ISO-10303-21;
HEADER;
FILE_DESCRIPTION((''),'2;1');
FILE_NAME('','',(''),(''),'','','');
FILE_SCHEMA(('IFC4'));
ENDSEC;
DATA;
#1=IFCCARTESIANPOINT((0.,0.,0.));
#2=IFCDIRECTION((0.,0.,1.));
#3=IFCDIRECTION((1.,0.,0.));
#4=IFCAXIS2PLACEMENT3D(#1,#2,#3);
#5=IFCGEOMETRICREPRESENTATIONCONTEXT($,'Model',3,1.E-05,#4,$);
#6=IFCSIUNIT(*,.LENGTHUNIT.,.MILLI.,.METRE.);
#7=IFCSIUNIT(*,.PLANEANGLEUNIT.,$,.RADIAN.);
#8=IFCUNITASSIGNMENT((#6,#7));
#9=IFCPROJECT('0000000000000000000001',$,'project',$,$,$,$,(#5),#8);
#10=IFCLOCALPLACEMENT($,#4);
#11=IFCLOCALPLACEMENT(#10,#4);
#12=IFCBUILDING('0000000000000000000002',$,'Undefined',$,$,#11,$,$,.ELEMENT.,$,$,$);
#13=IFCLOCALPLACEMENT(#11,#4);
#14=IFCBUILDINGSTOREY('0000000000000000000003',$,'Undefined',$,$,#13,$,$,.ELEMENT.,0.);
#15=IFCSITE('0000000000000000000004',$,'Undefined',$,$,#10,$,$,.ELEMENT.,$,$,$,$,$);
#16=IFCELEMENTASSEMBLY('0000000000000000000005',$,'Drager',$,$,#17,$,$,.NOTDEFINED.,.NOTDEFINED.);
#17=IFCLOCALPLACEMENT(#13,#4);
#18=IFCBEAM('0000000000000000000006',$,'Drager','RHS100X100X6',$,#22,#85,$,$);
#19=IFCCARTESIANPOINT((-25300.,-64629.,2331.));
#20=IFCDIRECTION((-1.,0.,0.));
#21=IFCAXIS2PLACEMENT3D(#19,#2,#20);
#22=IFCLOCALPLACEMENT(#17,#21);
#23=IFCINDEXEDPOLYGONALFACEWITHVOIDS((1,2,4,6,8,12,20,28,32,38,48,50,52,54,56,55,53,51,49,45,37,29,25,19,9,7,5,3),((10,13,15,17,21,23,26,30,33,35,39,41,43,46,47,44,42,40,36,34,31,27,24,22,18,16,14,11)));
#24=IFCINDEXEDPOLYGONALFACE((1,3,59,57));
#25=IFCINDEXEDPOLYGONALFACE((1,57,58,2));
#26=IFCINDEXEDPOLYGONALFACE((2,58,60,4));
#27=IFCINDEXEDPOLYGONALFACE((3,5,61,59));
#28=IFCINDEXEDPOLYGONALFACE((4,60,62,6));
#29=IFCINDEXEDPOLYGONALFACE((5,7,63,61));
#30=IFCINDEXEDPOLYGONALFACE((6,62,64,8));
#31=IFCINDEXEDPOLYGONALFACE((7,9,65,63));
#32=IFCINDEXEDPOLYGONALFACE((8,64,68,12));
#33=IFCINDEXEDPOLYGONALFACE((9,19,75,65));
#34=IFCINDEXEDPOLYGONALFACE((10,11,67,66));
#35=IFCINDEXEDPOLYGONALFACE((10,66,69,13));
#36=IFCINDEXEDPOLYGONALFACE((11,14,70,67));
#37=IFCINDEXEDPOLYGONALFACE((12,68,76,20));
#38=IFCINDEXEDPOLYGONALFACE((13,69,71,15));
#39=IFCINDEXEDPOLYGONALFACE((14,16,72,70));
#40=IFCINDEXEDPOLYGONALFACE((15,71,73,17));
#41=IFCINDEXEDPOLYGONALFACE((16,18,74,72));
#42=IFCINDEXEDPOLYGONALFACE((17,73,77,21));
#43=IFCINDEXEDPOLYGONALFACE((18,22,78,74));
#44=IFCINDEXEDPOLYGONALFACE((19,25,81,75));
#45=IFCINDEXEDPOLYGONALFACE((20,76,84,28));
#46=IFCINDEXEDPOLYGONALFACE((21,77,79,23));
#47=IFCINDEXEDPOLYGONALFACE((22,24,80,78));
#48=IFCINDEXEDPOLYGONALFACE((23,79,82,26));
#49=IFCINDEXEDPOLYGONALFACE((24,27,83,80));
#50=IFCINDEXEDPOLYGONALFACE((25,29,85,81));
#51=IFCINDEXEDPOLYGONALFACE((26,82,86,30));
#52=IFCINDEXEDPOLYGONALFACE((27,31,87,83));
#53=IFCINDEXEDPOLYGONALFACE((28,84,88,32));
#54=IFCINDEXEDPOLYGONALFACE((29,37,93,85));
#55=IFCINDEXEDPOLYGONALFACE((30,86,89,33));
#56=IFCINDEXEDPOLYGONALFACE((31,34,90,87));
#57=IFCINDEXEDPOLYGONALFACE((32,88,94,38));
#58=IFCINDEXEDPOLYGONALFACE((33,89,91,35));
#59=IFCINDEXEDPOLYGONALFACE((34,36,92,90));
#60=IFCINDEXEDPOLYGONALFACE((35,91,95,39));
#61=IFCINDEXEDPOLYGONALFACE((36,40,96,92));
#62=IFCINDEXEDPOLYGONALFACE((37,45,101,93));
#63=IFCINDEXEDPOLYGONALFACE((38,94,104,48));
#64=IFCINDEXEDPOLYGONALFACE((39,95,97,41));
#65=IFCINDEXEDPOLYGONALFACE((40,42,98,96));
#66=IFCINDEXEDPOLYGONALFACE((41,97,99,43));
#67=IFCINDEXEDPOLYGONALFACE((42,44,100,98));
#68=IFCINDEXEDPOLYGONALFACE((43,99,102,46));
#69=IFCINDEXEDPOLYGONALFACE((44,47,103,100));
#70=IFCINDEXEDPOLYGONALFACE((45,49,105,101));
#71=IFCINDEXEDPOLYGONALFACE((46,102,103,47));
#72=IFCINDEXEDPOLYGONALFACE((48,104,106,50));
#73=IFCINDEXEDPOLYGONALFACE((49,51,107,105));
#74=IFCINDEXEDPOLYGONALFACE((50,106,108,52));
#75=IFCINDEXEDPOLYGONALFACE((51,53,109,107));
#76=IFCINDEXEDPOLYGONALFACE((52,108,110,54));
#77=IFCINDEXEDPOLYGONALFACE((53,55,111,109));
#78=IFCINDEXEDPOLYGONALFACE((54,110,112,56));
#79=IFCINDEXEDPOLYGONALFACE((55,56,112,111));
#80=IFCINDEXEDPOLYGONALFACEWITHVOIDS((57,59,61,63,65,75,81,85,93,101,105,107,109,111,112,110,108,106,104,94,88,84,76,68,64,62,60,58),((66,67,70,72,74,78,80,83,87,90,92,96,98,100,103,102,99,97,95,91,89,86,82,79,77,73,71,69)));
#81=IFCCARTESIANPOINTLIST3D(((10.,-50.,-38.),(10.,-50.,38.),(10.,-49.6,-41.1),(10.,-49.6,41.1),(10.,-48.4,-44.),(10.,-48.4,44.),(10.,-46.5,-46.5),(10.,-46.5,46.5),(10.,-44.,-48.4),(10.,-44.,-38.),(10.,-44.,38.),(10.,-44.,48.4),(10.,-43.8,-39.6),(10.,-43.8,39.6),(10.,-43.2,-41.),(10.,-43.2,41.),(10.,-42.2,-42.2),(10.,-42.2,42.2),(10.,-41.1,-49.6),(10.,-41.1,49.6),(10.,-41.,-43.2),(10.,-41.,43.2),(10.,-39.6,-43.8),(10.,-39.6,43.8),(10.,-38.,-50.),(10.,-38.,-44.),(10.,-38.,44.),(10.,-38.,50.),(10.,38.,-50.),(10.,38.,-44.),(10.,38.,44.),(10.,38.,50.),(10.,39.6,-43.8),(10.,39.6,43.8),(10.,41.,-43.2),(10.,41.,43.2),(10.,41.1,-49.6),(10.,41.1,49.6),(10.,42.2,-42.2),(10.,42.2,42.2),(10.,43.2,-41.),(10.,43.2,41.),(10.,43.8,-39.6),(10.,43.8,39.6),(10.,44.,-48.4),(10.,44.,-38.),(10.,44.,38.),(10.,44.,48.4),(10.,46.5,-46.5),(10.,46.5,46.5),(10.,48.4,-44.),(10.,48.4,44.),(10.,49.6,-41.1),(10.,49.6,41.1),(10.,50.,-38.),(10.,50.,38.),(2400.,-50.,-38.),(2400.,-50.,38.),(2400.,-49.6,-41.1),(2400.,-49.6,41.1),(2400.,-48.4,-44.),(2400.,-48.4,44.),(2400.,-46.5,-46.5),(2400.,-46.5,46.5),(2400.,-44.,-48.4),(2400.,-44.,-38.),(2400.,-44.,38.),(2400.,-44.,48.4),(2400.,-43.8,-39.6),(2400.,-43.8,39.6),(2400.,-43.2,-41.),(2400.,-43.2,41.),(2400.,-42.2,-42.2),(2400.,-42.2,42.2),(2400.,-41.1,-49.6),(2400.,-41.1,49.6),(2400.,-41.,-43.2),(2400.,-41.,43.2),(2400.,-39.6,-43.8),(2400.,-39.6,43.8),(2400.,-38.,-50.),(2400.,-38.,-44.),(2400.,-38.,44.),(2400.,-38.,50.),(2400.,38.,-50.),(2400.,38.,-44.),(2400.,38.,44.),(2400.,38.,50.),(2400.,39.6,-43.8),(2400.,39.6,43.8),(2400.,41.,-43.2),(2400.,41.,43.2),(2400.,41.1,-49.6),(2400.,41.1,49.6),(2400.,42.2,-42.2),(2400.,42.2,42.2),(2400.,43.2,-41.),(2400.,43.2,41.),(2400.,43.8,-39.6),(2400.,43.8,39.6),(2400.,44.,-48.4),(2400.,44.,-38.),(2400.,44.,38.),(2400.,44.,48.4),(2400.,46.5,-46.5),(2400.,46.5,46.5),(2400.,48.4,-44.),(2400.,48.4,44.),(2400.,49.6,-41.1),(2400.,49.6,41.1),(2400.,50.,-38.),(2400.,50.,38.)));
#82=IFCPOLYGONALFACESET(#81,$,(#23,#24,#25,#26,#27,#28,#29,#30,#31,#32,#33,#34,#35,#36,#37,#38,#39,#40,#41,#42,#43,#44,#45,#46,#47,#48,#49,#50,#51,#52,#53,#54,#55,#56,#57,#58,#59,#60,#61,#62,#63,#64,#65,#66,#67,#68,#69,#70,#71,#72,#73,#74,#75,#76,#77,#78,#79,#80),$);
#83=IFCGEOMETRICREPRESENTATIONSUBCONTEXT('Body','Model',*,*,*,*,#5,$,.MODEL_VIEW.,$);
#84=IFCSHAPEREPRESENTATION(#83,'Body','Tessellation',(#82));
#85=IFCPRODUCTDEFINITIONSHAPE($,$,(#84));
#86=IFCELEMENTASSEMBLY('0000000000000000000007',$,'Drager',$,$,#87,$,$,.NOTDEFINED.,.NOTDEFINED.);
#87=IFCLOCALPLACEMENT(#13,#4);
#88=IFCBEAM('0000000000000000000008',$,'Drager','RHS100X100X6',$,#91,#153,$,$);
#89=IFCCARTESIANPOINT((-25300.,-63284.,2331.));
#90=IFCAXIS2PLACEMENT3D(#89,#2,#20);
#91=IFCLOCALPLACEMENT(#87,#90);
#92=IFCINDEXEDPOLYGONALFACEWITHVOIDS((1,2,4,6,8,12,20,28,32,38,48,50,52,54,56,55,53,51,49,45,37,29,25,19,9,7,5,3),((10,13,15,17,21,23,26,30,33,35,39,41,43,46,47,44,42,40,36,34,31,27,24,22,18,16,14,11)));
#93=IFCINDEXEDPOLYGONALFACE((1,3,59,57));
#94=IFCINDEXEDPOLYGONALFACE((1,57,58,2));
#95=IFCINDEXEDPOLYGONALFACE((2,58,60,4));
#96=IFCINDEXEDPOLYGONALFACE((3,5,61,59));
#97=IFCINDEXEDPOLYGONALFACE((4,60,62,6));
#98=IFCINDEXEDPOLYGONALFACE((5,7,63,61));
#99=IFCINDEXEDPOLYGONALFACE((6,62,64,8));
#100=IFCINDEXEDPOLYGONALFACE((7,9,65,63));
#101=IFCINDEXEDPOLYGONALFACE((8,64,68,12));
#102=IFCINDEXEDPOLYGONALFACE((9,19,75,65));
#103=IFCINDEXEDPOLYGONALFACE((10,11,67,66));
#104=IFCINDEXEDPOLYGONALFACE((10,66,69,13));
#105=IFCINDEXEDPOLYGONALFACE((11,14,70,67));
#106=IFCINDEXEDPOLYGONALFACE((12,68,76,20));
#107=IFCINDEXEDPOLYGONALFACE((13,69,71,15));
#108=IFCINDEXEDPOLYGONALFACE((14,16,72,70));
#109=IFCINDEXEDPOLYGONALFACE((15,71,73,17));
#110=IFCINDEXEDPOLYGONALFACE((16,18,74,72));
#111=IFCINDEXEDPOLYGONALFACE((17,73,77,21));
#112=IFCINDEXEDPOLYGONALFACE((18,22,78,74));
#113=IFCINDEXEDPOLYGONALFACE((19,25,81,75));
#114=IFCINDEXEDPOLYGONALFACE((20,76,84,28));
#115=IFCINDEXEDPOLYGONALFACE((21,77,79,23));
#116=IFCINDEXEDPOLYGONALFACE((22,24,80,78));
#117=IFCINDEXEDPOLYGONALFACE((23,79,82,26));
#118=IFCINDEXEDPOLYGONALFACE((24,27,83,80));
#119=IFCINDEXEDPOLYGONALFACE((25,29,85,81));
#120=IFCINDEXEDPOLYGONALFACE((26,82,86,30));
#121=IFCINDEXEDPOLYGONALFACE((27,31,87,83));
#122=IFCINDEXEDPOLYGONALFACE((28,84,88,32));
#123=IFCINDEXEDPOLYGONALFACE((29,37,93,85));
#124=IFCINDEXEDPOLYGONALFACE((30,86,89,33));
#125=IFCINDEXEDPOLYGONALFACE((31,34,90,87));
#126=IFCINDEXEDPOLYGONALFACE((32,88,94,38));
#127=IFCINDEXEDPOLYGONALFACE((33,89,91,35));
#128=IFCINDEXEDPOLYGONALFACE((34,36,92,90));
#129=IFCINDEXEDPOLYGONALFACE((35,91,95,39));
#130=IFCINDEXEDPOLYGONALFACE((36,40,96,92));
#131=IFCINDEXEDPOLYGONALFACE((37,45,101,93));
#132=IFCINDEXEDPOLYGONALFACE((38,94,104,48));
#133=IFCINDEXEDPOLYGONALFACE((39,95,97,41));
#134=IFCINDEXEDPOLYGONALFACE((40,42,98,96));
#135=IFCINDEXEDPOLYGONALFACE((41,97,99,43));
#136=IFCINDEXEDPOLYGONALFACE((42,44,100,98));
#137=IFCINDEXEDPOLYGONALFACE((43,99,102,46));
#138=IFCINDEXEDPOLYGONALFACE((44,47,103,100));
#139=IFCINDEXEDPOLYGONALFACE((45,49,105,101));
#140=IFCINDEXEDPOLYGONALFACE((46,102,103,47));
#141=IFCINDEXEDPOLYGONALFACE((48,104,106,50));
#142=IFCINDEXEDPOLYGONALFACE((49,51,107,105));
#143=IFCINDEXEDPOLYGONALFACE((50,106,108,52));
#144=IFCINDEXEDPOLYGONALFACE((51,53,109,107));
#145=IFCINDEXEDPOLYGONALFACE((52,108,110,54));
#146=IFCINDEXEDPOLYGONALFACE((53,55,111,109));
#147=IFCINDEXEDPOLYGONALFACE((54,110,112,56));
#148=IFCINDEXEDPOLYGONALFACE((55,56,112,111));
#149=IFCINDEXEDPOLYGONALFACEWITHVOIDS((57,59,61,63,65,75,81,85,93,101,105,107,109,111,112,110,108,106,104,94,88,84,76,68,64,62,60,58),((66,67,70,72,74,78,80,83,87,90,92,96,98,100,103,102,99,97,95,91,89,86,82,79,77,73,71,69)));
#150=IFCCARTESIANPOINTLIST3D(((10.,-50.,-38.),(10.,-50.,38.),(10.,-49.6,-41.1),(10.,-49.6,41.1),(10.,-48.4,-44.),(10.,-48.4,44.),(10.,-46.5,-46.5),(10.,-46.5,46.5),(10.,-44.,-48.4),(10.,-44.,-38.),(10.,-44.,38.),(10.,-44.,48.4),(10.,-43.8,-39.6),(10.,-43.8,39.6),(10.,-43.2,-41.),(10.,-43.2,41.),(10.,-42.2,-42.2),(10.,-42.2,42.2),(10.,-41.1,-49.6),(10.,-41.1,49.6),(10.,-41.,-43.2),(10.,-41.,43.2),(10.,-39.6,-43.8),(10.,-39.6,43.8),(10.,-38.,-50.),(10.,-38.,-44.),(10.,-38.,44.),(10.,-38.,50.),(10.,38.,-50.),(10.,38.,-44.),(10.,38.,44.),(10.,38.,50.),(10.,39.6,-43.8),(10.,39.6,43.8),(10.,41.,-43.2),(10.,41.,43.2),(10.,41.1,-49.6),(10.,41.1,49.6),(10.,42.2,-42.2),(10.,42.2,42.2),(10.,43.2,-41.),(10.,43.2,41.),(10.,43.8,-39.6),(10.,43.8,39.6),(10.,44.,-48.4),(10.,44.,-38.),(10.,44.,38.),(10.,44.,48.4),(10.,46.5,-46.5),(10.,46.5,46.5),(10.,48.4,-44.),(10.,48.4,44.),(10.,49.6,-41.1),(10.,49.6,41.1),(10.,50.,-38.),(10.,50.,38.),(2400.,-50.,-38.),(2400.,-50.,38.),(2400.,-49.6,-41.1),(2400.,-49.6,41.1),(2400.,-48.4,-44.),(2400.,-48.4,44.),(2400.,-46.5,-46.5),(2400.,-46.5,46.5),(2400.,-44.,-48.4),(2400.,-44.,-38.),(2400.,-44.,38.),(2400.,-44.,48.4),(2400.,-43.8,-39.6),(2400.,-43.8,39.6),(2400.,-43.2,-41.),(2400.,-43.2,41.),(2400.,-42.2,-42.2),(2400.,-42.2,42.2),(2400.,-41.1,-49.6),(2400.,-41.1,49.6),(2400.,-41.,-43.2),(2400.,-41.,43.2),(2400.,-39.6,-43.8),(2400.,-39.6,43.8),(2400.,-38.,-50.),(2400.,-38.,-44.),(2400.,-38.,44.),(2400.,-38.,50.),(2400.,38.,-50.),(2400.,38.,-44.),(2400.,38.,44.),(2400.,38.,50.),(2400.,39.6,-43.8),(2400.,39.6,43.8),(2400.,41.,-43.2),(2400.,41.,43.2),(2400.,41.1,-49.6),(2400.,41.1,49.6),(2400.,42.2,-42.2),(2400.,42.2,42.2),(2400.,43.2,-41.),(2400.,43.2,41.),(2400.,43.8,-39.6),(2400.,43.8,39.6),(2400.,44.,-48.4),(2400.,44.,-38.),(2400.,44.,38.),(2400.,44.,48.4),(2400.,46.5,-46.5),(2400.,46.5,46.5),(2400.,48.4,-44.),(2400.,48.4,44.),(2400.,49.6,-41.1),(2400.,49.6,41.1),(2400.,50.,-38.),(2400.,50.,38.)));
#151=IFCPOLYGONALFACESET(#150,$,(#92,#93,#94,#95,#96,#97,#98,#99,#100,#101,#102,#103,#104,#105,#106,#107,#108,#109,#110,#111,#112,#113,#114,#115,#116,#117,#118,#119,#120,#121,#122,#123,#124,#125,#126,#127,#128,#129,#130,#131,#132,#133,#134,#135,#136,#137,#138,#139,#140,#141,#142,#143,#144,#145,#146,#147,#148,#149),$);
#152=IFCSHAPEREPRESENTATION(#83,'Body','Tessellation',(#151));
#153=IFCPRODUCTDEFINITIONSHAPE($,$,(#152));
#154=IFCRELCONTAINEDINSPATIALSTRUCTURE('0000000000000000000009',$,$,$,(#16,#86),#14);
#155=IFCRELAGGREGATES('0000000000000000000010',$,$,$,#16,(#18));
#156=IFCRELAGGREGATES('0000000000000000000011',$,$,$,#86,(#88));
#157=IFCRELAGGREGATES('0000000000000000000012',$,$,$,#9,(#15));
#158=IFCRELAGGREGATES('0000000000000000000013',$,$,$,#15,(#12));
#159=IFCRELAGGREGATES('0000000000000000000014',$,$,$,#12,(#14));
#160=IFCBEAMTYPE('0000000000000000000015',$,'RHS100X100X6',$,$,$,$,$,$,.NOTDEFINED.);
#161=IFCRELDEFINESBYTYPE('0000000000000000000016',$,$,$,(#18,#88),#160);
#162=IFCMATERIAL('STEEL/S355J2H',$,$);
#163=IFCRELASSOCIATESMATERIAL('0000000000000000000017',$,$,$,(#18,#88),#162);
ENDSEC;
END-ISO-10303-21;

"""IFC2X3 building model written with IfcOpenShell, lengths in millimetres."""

from ifc_helpers import new_model, si_unit, frame, origin_with_axes, origin_2d_with_axis, place, context, subcontext, project, spatial, hollow_rectangle, extrude, clip, halfspace, material, type_object, element, aggregate, save


model = new_model("IFC2X3")

# Units and contexts
model_context = context("Model", 3, precision=1e-05, world=origin_with_axes())
body_context = subcontext(model_context, "Body", "Model", "MODEL_VIEW")
ifc_project = project(units=[si_unit("LENGTHUNIT", "METRE", prefix="MILLI"), si_unit("PLANEANGLEUNIT", "RADIAN")], contexts=[model_context])

# Site, building, storey
site_placement = place(None, origin_with_axes())
site = spatial("IfcSite", under=ifc_project, at=site_placement, Name="Undefined", CompositionType="ELEMENT")
building_placement = place(site_placement, origin_with_axes())
building = spatial("IfcBuilding", under=site, at=building_placement, Name="Undefined", CompositionType="ELEMENT")
storey_placement = place(building_placement, origin_with_axes())
storey = spatial("IfcBuildingStorey", under=building, at=storey_placement, Name="Undefined", CompositionType="ELEMENT", Elevation=0.0)

# Shared definitions
ifc_material_1 = material(Name="STEEL/S355J2H")

# Element assemblies, beams
assembly_1_placement = place(storey_placement, origin_with_axes())
assembly_1 = element("IfcElementAssembly", 1, at=assembly_1_placement, inside=storey, Name="Drager", AssemblyPlace="NOTDEFINED", PredefinedType="NOTDEFINED")
beam_type_1 = type_object("IfcBeamType", Name="RHS100X100X6", PredefinedType="NOTDEFINED")
beam_1_placement = place(assembly_1_placement, frame((-25300.0, -64629.0, 2331.0), z_axis=(0.0, 0.0, 1.0), x_axis=(-1.0, 0.0, 0.0)))
beam_1 = element("IfcBeam", 2, at=beam_1_placement, type_object=beam_type_1, material=ifc_material_1, Name="Drager", Description="RHS100X100X6", context=body_context, shape_type="Clipping", body=[
    clip(clip(extrude(hollow_rectangle(XDim=100.0, YDim=100.0, WallThickness=6.0, InnerFilletRadius=6.0, OuterFilletRadius=12.0, at=origin_2d_with_axis()), frame((2410.0, 0.0, 0.0), z_axis=(-1.0, 0.0, 0.0), x_axis=(0.0, -1.0, 0.0)), (0.0, 0.0, 1.0), 2410.0), halfspace(frame((2400.0, 0.0, -50.0), z_axis=(-1.0, 0.0, 0.0), x_axis=(0.0, 1.0, 0.0)), True)), halfspace(frame((10.0, 50.0, 0.0), z_axis=(1.0, 0.0, 0.0), x_axis=(0.0, 0.0, -1.0)), True)),
])
assembly_2_placement = place(storey_placement, origin_with_axes())
assembly_2 = element("IfcElementAssembly", 3, at=assembly_2_placement, inside=storey, Name="Drager", AssemblyPlace="NOTDEFINED", PredefinedType="NOTDEFINED")
beam_2_placement = place(assembly_2_placement, frame((-25300.0, -63284.0, 2331.0), z_axis=(0.0, 0.0, 1.0), x_axis=(-1.0, 0.0, 0.0)))
beam_2 = element("IfcBeam", 4, at=beam_2_placement, type_object=beam_type_1, material=ifc_material_1, Name="Drager", Description="RHS100X100X6", context=body_context, shape_type="Clipping", body=[
    clip(clip(extrude(hollow_rectangle(XDim=100.0, YDim=100.0, WallThickness=6.0, InnerFilletRadius=6.0, OuterFilletRadius=12.0, at=origin_2d_with_axis()), frame((2410.0, 0.0, 0.0), z_axis=(-1.0, 0.0, 0.0), x_axis=(0.0, -1.0, 0.0)), (0.0, 0.0, 1.0), 2410.0), halfspace(frame((2400.0, 0.0, -50.0), z_axis=(-1.0, 0.0, 0.0), x_axis=(0.0, 1.0, 0.0)), True)), halfspace(frame((10.0, 50.0, 0.0), z_axis=(1.0, 0.0, 0.0), x_axis=(0.0, 0.0, -1.0)), True)),
])

aggregate(assembly_1, [beam_1])
aggregate(assembly_2, [beam_2])

save(model, "model.ifc")
